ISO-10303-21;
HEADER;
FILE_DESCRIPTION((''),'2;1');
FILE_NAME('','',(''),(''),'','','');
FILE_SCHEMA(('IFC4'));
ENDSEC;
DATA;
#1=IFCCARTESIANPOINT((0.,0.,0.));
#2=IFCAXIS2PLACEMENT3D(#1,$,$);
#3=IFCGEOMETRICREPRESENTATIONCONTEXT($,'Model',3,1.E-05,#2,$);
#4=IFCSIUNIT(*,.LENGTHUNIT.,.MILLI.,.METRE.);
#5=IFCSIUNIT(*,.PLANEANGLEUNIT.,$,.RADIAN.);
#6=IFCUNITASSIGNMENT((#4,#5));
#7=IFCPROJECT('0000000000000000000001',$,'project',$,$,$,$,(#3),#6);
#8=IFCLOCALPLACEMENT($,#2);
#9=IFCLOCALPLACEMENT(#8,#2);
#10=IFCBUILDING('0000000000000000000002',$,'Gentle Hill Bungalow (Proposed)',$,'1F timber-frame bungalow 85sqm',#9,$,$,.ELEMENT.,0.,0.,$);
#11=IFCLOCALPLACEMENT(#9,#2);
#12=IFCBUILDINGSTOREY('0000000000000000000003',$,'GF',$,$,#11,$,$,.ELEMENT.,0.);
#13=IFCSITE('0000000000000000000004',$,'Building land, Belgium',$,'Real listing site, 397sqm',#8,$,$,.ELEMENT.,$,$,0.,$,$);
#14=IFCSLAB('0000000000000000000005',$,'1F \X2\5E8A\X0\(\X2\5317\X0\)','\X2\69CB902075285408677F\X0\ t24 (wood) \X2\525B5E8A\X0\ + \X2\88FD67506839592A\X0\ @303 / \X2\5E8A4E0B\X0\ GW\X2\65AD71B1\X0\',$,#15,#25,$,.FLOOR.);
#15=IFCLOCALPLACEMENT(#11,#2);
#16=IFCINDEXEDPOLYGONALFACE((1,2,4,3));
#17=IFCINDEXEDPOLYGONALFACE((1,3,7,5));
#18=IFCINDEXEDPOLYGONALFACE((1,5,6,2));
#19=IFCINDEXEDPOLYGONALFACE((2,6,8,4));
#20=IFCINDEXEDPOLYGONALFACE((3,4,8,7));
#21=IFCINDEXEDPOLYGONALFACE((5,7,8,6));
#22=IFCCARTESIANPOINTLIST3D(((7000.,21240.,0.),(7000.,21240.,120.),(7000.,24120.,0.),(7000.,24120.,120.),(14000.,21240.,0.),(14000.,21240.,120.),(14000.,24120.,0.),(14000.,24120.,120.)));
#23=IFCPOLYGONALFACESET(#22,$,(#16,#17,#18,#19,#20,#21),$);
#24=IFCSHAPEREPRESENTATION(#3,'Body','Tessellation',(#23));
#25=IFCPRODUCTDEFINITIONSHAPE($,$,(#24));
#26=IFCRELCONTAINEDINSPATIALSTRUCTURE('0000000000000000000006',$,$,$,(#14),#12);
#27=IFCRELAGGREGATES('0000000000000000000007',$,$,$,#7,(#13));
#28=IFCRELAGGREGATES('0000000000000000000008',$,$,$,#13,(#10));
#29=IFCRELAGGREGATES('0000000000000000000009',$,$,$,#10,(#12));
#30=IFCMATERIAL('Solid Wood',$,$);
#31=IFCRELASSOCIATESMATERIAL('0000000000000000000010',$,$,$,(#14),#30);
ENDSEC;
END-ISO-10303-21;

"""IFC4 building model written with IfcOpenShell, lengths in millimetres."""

from ifc_helpers import new_model, si_unit, frame, frame_2d, origin, place, context, project, spatial, rectangle, extrude, material, element, save


model = new_model("IFC4")

# Units and contexts
model_context = context("Model", 3, precision=1e-05, world=origin())
ifc_project = project(units=[si_unit("LENGTHUNIT", "METRE", prefix="MILLI"), si_unit("PLANEANGLEUNIT", "RADIAN")], contexts=[model_context])

# Site, building, storey
site_placement = place(None, origin())
site = spatial("IfcSite", under=ifc_project, at=site_placement, Name="Building land, Belgium", ObjectType="Real listing site, 397sqm", CompositionType="ELEMENT", RefElevation=0.0)
building_placement = place(site_placement, origin())
building = spatial("IfcBuilding", under=site, at=building_placement, Name="Gentle Hill Bungalow (Proposed)", ObjectType="1F timber-frame bungalow 85sqm", CompositionType="ELEMENT", ElevationOfRefHeight=0.0, ElevationOfTerrain=0.0)
storey_placement = place(building_placement, origin())
storey = spatial("IfcBuildingStorey", under=building, at=storey_placement, Name="GF", CompositionType="ELEMENT", Elevation=0.0)

# Slab
ifc_material_1 = material(Name="Solid Wood")
slab_1_placement = place(storey_placement, frame((3500.0, 10620.0, 0.0)))
element("IfcSlab", 1, at=slab_1_placement, inside=storey, material=ifc_material_1, Name="1F 床(北)", Description="構造用合板 t24 (wood) 剛床 + 製材根太 @303 / 床下 GW断熱", PredefinedType="FLOOR", context=model_context, shape_type="SweptSolid", body=[
    extrude(rectangle(XDim=7000.0, YDim=2880.0, at=frame_2d((3500.0, 1440.0))), frame((3500.0, 10620.0, 0.0)), (0.0, 0.0, 1.0), 120.0),
])

save(model, "model.ifc")
